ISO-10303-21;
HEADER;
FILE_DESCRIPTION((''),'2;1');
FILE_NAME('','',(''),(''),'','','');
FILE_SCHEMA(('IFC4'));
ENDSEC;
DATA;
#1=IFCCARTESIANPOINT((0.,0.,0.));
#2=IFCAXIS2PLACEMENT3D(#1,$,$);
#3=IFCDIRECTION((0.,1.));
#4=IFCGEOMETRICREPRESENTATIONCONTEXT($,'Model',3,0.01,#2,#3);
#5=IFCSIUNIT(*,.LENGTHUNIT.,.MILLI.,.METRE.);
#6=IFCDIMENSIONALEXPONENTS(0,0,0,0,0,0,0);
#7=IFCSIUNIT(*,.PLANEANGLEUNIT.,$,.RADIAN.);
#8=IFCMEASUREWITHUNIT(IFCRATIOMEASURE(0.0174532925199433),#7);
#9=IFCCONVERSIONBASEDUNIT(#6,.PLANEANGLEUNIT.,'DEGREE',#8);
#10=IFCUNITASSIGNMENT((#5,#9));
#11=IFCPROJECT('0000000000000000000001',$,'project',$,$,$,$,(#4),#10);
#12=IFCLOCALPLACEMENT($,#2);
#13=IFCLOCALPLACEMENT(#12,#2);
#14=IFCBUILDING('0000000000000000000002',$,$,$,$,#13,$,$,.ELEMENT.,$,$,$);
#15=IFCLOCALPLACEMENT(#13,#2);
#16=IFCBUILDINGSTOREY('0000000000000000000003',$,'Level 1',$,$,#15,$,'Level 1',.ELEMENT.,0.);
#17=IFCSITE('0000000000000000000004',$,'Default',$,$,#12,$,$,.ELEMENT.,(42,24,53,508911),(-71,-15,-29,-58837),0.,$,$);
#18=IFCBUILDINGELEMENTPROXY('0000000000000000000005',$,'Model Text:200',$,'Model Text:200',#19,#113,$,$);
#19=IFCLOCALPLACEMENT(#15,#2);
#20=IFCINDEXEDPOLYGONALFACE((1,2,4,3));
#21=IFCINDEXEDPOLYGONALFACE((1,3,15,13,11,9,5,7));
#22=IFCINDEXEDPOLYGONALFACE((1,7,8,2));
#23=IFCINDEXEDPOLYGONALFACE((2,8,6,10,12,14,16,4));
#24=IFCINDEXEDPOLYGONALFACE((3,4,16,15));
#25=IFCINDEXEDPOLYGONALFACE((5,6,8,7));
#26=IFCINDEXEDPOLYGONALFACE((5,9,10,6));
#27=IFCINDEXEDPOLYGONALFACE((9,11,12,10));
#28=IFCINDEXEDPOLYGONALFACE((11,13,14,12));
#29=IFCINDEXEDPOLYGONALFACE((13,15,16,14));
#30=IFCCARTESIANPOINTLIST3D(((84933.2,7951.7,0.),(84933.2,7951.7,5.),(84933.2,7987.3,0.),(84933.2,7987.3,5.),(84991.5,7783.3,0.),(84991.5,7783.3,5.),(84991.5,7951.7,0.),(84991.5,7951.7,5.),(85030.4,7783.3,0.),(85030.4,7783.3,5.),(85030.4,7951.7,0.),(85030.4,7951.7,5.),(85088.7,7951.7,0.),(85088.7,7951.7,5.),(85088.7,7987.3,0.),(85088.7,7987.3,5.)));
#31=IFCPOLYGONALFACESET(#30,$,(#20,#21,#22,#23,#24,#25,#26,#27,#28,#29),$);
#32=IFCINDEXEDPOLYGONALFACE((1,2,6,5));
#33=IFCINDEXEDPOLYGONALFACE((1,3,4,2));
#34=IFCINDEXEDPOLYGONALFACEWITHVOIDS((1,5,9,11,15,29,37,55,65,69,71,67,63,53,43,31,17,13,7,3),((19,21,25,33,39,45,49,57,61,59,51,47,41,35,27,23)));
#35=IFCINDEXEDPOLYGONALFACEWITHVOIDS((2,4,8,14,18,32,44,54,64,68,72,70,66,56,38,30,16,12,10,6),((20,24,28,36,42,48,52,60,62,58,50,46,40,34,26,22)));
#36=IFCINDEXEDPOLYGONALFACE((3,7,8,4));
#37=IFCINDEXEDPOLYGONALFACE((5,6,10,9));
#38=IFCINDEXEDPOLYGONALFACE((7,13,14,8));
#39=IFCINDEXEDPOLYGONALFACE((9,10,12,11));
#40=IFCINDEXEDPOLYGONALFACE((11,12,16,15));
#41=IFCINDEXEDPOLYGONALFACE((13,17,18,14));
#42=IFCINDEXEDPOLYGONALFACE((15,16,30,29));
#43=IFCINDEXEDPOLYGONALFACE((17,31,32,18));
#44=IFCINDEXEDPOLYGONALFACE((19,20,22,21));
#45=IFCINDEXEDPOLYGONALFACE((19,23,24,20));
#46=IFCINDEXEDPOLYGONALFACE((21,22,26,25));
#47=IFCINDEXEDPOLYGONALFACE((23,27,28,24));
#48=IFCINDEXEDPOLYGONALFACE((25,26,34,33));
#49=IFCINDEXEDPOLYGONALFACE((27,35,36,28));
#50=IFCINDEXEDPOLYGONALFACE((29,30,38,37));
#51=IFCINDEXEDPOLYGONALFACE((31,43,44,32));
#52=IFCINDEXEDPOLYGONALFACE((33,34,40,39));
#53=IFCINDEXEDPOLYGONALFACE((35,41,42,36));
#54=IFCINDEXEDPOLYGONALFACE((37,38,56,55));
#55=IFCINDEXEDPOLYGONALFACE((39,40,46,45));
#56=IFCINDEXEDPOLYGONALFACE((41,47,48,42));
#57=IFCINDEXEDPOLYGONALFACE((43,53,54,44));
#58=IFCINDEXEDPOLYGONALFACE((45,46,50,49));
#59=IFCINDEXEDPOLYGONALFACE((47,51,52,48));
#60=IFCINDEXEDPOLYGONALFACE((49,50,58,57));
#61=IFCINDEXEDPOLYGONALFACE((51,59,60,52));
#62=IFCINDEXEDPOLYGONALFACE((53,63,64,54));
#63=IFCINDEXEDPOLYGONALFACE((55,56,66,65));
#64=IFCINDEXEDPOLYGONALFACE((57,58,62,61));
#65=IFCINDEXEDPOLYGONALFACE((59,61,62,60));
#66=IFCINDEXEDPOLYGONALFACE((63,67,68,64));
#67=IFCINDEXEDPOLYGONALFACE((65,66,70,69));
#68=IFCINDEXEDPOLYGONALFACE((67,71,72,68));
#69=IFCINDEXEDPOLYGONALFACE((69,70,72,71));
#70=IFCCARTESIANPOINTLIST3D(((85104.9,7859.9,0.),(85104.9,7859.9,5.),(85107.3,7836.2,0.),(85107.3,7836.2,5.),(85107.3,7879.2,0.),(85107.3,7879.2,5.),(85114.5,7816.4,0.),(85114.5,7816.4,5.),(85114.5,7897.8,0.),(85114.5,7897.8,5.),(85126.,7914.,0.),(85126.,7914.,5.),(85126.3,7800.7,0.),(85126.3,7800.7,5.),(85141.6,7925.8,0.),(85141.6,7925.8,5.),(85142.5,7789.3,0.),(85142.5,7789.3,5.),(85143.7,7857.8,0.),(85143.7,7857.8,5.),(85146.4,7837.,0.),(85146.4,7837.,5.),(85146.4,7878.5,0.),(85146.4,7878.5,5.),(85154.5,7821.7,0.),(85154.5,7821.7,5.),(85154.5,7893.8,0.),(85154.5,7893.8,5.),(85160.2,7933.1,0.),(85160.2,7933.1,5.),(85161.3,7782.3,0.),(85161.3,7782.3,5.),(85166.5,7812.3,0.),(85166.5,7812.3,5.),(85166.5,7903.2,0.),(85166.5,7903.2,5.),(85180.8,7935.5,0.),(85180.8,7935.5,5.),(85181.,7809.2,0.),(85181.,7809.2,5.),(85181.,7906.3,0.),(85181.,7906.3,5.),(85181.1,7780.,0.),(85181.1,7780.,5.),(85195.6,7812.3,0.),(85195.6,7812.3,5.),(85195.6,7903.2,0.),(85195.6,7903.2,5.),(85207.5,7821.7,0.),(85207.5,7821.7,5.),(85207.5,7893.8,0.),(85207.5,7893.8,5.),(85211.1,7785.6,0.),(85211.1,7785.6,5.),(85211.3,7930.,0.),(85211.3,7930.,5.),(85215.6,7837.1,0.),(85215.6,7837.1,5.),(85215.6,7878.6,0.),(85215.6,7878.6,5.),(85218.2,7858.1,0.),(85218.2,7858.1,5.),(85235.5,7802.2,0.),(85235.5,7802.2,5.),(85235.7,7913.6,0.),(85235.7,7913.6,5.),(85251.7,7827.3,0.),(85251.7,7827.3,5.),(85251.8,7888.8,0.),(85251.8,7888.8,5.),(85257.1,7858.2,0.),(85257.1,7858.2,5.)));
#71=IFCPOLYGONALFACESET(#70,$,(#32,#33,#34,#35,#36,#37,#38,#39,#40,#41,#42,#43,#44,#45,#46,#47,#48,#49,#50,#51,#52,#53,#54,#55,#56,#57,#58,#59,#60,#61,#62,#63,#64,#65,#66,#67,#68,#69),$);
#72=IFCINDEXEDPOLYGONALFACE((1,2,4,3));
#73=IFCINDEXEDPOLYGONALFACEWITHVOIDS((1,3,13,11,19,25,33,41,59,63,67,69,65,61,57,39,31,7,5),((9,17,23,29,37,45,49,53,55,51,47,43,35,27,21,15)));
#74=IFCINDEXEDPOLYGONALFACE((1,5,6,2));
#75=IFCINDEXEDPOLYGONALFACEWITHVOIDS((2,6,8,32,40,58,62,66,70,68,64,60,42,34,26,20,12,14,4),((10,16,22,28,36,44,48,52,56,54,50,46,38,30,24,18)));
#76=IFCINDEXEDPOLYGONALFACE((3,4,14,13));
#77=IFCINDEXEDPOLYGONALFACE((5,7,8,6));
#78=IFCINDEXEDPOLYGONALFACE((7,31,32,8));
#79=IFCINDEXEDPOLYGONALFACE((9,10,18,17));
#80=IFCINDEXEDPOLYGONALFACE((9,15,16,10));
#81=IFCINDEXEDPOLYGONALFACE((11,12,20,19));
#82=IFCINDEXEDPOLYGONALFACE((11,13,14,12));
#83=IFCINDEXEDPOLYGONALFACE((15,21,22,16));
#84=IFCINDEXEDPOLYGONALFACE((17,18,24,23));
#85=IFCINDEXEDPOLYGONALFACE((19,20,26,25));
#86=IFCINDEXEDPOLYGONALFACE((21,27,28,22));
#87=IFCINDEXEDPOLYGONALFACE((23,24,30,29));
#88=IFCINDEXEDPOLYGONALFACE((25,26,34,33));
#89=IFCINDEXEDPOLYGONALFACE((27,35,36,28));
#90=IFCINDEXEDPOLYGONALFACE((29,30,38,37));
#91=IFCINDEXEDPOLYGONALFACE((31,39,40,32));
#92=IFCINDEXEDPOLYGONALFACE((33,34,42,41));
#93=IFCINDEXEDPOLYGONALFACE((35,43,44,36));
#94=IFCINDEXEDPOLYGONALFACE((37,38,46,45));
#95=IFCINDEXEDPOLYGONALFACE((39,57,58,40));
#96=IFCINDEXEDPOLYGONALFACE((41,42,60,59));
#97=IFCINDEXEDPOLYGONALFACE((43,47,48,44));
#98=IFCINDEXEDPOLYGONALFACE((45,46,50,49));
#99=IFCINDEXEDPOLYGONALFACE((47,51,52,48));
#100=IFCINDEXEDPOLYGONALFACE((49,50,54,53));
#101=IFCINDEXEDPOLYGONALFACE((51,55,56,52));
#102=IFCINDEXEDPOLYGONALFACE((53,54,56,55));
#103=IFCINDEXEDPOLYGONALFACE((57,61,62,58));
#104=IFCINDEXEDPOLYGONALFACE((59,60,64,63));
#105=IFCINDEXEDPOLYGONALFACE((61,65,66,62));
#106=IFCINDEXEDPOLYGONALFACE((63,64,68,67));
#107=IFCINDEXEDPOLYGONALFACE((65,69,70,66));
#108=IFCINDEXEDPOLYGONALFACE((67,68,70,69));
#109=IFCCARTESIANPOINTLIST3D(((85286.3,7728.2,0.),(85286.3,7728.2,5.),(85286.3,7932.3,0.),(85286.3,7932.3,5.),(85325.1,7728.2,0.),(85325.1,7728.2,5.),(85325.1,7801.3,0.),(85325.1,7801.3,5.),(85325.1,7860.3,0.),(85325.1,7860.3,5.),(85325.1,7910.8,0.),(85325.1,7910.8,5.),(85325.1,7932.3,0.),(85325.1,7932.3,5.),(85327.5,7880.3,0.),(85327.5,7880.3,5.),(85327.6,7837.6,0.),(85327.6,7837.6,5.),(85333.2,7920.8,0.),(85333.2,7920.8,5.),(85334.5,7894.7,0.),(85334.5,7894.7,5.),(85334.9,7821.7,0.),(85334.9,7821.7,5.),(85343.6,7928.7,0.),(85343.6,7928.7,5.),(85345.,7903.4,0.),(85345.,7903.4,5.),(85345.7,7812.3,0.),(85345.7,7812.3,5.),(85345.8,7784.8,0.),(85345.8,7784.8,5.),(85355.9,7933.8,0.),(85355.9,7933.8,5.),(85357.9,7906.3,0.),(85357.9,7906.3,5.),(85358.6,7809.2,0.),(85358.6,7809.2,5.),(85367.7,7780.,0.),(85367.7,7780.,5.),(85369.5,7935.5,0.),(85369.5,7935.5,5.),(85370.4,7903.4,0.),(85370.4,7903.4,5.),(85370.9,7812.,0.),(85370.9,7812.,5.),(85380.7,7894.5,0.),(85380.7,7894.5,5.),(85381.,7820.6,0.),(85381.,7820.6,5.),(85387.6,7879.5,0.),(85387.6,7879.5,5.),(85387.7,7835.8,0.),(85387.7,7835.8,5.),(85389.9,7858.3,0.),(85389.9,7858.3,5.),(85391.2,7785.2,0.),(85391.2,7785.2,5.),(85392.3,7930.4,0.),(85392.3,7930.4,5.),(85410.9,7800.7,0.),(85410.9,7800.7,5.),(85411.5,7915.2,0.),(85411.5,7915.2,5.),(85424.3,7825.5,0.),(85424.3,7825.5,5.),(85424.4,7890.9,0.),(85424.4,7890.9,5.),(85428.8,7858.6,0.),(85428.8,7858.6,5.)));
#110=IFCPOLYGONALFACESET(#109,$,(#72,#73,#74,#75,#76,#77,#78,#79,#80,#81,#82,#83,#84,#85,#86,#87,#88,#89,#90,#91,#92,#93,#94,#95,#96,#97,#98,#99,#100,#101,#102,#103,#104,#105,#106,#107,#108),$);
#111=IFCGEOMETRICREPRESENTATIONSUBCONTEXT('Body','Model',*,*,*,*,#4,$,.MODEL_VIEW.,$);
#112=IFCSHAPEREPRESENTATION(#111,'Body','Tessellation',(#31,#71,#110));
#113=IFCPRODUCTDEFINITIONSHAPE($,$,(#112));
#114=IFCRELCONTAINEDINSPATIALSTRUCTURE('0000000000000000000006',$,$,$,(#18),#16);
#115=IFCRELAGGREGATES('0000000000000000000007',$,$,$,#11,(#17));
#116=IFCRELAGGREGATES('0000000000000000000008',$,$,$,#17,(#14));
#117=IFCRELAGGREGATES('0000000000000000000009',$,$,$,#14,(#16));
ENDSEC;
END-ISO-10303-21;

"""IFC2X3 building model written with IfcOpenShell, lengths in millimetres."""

from ifc_helpers import new_model, entity, si_unit, converted_unit, direction, frame, origin, place, context, subcontext, project, spatial, polyline, outline, extrude, element, save


model = new_model("IFC2X3")

# Units and contexts
model_context = context("Model", 3, precision=0.01, world=origin(), true_north=direction((0.0, 1.0)))
body_context = subcontext(model_context, "Body", "Model", "MODEL_VIEW")
ifc_project = project(units=[si_unit("LENGTHUNIT", "METRE", prefix="MILLI"), converted_unit("PLANEANGLEUNIT", "DEGREE", entity("IfcRatioMeasure", 0.0174532925199433), si_unit("PLANEANGLEUNIT", "RADIAN"), dimensions=[0, 0, 0, 0, 0, 0, 0])], contexts=[model_context])

# Site, building, storey
site_placement = place(None, origin())
site = spatial("IfcSite", under=ifc_project, at=site_placement, Name="Default", CompositionType="ELEMENT", RefLatitude=(42, 24, 53, 508911), RefLongitude=(-71, -15, -29, -58837), RefElevation=0.0)
building_placement = place(site_placement, origin())
building = spatial("IfcBuilding", under=site, at=building_placement, CompositionType="ELEMENT")
storey_placement = place(building_placement, origin())
storey = spatial("IfcBuildingStorey", under=building, at=storey_placement, Name="Level 1", LongName="Level 1", CompositionType="ELEMENT", Elevation=0.0)

# Building element proxy
proxy_1_placement = place(storey_placement, origin())
element("IfcBuildingElementProxy", 1, at=proxy_1_placement, inside=storey, Name="Model Text:200", ObjectType="Model Text:200", context=body_context, shape_type="SweptSolid", body=[
    extrude(outline(polyline([(-19.4, -135.2), (19.4, -135.2), (19.4, 33.2), (77.7, 33.2), (77.7, 68.8), (-77.7, 68.8), (-77.7, 33.2), (-19.4, 33.2), (-19.4, -135.2)])), frame((85010.9, 7918.5, 0.0)), (0.0, 0.0, 1.0), 5.0),
    extrude(outline(polyline([(-8.8, -65.7), (15.1, -65.7), (35.5, -60.5), (52.3, -50.4), (65.3, -35.4), (74.1, -17.3), (78.4, 2.1), (75.9, 32.5), (61.8, 58.5), (38.4, 77.1), (8.3, 85.6), (-22.7, 83.3), (-49.0, 69.9), (-67.8, 47.3), (-76.3, 17.5), (-76.0, -3.3), (-70.7, -22.5), (-60.5, -39.2), (-45.5, -52.3), (-27.7, -61.4), (-8.8, -65.7)]), holes=[polyline([(-2.7, -27.2), (-23.1, -22.5), (-37.5, -12.9), (-45.7, 0.0), (-47.3, 14.8), (-42.7, 28.9), (-32.2, 39.9), (-16.3, 46.3), (4.5, 46.9), (25.1, 42.1), (39.6, 32.6), (47.7, 19.7), (49.4, 5.0), (44.8, -9.2), (34.2, -20.2), (18.2, -26.7), (-2.7, -27.2)])]), frame((85171.1, 7857.8, 0.0), z_axis=(0.0, 0.0, 1.0), x_axis=(0.100608, -0.994926, 0.0)), (0.0, 0.0, 1.0), 5.0),
    extrude(outline(polyline([(-73.1, -75.4), (130.9, -75.4), (130.9, -36.6), (57.8, -36.6), (74.3, -15.9), (79.1, 6.0), (73.9, 29.5), (58.4, 49.2), (33.6, 62.6), (0.5, 67.1), (-31.8, 62.8), (-56.1, 49.8), (-71.3, 30.7), (-76.4, 7.8), (-74.7, -5.8), (-69.6, -18.1), (-61.7, -28.5), (-51.7, -36.6), (-73.1, -36.6), (-73.1, -75.4)]), holes=[polyline([(-1.2, -36.6), (-21.2, -34.2), (-35.6, -27.2), (-44.3, -16.7), (-47.2, -3.8), (-44.3, 8.7), (-35.4, 19.0), (-20.4, 25.9), (0.8, 28.2), (23.3, 26.0), (38.5, 19.3), (47.1, 9.2), (49.9, -3.1), (46.8, -16.0), (37.4, -26.8), (21.5, -34.1), (-1.2, -36.6)])]), frame((85361.7, 7859.1, 0.0), z_axis=(0.0, 0.0, 1.0), x_axis=(0.0, -1.0, 0.0)), (0.0, 0.0, 1.0), 5.0),
])

save(model, "model.ifc")
